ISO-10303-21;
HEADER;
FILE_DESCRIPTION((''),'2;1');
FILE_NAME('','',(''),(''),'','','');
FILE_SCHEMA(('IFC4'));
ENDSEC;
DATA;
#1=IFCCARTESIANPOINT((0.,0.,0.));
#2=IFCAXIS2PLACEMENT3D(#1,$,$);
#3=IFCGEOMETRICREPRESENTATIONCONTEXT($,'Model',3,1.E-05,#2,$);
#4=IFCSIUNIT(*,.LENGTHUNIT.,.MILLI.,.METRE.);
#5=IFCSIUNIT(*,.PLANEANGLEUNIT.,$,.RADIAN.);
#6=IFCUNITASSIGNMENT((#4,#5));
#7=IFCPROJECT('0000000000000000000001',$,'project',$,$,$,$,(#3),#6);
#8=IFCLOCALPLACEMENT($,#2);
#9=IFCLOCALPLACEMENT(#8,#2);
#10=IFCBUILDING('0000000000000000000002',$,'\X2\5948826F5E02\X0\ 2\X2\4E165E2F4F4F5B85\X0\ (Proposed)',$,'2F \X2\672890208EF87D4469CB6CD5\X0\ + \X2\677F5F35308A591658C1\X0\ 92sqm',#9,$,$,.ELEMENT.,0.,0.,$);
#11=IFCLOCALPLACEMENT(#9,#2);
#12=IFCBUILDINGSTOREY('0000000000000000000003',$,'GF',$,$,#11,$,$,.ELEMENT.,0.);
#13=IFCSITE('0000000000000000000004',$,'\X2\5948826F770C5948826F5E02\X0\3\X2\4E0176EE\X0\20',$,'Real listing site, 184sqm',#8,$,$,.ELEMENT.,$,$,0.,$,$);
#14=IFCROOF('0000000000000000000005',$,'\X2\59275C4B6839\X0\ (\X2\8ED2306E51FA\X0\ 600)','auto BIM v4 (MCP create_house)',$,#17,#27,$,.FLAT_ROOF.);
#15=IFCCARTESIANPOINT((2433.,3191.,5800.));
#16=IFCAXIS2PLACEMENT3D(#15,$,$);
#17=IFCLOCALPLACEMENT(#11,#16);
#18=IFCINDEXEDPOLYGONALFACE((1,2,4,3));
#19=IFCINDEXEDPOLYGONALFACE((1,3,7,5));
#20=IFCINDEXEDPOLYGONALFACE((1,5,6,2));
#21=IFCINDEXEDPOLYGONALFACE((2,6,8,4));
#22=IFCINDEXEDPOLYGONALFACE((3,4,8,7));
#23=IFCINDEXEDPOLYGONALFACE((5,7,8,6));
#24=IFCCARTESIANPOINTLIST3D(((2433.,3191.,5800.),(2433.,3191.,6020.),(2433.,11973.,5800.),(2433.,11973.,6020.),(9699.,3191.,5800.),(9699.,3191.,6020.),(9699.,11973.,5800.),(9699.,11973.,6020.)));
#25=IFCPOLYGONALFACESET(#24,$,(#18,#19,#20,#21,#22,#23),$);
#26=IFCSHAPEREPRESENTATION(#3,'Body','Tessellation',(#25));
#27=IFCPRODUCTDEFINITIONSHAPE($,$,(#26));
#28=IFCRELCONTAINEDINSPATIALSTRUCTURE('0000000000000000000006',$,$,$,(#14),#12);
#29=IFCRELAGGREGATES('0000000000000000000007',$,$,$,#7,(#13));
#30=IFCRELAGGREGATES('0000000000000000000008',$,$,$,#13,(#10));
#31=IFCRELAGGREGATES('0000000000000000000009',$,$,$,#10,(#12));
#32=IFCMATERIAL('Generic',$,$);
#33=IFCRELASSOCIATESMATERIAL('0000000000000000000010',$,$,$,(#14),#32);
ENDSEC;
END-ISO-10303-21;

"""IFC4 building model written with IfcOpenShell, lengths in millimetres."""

from ifc_helpers import new_model, si_unit, frame, frame_2d, origin, place, context, project, spatial, rectangle, extrude, material, element, save


model = new_model("IFC4")

# Units and contexts
model_context = context("Model", 3, precision=1e-05, world=origin())
ifc_project = project(units=[si_unit("LENGTHUNIT", "METRE", prefix="MILLI"), si_unit("PLANEANGLEUNIT", "RADIAN")], contexts=[model_context])

# Site, building, storey
site_placement = place(None, origin())
site = spatial("IfcSite", under=ifc_project, at=site_placement, Name="奈良県奈良市3丁目20", ObjectType="Real listing site, 184sqm", CompositionType="ELEMENT", RefElevation=0.0)
building_placement = place(site_placement, origin())
building = spatial("IfcBuilding", under=site, at=building_placement, Name="奈良市 2世帯住宅 (Proposed)", ObjectType="2F 木造軸組構法 + 板張り外壁 92sqm", CompositionType="ELEMENT", ElevationOfRefHeight=0.0, ElevationOfTerrain=0.0)
storey_placement = place(building_placement, origin())
storey = spatial("IfcBuildingStorey", under=building, at=storey_placement, Name="GF", CompositionType="ELEMENT", Elevation=0.0)

# Shared definitions
ifc_material = material(Name="Generic")

# Roof
roof_placement = place(storey_placement, frame((2433.0, 3191.0, 5800.0)))
element("IfcRoof", 1, at=roof_placement, inside=storey, material=ifc_material, Name="大屋根 (軒の出 600)", Description="auto BIM v4 (MCP create_house)", PredefinedType="FLAT_ROOF", context=model_context, shape_type="SweptSolid", body=[
    extrude(rectangle(XDim=7266.0, YDim=8782.0, at=frame_2d((3633.0, 4391.0))), frame((2433.0, 3191.0, 5800.0)), (0.0, 0.0, 1.0), 220.0),
])

save(model, "model.ifc")
